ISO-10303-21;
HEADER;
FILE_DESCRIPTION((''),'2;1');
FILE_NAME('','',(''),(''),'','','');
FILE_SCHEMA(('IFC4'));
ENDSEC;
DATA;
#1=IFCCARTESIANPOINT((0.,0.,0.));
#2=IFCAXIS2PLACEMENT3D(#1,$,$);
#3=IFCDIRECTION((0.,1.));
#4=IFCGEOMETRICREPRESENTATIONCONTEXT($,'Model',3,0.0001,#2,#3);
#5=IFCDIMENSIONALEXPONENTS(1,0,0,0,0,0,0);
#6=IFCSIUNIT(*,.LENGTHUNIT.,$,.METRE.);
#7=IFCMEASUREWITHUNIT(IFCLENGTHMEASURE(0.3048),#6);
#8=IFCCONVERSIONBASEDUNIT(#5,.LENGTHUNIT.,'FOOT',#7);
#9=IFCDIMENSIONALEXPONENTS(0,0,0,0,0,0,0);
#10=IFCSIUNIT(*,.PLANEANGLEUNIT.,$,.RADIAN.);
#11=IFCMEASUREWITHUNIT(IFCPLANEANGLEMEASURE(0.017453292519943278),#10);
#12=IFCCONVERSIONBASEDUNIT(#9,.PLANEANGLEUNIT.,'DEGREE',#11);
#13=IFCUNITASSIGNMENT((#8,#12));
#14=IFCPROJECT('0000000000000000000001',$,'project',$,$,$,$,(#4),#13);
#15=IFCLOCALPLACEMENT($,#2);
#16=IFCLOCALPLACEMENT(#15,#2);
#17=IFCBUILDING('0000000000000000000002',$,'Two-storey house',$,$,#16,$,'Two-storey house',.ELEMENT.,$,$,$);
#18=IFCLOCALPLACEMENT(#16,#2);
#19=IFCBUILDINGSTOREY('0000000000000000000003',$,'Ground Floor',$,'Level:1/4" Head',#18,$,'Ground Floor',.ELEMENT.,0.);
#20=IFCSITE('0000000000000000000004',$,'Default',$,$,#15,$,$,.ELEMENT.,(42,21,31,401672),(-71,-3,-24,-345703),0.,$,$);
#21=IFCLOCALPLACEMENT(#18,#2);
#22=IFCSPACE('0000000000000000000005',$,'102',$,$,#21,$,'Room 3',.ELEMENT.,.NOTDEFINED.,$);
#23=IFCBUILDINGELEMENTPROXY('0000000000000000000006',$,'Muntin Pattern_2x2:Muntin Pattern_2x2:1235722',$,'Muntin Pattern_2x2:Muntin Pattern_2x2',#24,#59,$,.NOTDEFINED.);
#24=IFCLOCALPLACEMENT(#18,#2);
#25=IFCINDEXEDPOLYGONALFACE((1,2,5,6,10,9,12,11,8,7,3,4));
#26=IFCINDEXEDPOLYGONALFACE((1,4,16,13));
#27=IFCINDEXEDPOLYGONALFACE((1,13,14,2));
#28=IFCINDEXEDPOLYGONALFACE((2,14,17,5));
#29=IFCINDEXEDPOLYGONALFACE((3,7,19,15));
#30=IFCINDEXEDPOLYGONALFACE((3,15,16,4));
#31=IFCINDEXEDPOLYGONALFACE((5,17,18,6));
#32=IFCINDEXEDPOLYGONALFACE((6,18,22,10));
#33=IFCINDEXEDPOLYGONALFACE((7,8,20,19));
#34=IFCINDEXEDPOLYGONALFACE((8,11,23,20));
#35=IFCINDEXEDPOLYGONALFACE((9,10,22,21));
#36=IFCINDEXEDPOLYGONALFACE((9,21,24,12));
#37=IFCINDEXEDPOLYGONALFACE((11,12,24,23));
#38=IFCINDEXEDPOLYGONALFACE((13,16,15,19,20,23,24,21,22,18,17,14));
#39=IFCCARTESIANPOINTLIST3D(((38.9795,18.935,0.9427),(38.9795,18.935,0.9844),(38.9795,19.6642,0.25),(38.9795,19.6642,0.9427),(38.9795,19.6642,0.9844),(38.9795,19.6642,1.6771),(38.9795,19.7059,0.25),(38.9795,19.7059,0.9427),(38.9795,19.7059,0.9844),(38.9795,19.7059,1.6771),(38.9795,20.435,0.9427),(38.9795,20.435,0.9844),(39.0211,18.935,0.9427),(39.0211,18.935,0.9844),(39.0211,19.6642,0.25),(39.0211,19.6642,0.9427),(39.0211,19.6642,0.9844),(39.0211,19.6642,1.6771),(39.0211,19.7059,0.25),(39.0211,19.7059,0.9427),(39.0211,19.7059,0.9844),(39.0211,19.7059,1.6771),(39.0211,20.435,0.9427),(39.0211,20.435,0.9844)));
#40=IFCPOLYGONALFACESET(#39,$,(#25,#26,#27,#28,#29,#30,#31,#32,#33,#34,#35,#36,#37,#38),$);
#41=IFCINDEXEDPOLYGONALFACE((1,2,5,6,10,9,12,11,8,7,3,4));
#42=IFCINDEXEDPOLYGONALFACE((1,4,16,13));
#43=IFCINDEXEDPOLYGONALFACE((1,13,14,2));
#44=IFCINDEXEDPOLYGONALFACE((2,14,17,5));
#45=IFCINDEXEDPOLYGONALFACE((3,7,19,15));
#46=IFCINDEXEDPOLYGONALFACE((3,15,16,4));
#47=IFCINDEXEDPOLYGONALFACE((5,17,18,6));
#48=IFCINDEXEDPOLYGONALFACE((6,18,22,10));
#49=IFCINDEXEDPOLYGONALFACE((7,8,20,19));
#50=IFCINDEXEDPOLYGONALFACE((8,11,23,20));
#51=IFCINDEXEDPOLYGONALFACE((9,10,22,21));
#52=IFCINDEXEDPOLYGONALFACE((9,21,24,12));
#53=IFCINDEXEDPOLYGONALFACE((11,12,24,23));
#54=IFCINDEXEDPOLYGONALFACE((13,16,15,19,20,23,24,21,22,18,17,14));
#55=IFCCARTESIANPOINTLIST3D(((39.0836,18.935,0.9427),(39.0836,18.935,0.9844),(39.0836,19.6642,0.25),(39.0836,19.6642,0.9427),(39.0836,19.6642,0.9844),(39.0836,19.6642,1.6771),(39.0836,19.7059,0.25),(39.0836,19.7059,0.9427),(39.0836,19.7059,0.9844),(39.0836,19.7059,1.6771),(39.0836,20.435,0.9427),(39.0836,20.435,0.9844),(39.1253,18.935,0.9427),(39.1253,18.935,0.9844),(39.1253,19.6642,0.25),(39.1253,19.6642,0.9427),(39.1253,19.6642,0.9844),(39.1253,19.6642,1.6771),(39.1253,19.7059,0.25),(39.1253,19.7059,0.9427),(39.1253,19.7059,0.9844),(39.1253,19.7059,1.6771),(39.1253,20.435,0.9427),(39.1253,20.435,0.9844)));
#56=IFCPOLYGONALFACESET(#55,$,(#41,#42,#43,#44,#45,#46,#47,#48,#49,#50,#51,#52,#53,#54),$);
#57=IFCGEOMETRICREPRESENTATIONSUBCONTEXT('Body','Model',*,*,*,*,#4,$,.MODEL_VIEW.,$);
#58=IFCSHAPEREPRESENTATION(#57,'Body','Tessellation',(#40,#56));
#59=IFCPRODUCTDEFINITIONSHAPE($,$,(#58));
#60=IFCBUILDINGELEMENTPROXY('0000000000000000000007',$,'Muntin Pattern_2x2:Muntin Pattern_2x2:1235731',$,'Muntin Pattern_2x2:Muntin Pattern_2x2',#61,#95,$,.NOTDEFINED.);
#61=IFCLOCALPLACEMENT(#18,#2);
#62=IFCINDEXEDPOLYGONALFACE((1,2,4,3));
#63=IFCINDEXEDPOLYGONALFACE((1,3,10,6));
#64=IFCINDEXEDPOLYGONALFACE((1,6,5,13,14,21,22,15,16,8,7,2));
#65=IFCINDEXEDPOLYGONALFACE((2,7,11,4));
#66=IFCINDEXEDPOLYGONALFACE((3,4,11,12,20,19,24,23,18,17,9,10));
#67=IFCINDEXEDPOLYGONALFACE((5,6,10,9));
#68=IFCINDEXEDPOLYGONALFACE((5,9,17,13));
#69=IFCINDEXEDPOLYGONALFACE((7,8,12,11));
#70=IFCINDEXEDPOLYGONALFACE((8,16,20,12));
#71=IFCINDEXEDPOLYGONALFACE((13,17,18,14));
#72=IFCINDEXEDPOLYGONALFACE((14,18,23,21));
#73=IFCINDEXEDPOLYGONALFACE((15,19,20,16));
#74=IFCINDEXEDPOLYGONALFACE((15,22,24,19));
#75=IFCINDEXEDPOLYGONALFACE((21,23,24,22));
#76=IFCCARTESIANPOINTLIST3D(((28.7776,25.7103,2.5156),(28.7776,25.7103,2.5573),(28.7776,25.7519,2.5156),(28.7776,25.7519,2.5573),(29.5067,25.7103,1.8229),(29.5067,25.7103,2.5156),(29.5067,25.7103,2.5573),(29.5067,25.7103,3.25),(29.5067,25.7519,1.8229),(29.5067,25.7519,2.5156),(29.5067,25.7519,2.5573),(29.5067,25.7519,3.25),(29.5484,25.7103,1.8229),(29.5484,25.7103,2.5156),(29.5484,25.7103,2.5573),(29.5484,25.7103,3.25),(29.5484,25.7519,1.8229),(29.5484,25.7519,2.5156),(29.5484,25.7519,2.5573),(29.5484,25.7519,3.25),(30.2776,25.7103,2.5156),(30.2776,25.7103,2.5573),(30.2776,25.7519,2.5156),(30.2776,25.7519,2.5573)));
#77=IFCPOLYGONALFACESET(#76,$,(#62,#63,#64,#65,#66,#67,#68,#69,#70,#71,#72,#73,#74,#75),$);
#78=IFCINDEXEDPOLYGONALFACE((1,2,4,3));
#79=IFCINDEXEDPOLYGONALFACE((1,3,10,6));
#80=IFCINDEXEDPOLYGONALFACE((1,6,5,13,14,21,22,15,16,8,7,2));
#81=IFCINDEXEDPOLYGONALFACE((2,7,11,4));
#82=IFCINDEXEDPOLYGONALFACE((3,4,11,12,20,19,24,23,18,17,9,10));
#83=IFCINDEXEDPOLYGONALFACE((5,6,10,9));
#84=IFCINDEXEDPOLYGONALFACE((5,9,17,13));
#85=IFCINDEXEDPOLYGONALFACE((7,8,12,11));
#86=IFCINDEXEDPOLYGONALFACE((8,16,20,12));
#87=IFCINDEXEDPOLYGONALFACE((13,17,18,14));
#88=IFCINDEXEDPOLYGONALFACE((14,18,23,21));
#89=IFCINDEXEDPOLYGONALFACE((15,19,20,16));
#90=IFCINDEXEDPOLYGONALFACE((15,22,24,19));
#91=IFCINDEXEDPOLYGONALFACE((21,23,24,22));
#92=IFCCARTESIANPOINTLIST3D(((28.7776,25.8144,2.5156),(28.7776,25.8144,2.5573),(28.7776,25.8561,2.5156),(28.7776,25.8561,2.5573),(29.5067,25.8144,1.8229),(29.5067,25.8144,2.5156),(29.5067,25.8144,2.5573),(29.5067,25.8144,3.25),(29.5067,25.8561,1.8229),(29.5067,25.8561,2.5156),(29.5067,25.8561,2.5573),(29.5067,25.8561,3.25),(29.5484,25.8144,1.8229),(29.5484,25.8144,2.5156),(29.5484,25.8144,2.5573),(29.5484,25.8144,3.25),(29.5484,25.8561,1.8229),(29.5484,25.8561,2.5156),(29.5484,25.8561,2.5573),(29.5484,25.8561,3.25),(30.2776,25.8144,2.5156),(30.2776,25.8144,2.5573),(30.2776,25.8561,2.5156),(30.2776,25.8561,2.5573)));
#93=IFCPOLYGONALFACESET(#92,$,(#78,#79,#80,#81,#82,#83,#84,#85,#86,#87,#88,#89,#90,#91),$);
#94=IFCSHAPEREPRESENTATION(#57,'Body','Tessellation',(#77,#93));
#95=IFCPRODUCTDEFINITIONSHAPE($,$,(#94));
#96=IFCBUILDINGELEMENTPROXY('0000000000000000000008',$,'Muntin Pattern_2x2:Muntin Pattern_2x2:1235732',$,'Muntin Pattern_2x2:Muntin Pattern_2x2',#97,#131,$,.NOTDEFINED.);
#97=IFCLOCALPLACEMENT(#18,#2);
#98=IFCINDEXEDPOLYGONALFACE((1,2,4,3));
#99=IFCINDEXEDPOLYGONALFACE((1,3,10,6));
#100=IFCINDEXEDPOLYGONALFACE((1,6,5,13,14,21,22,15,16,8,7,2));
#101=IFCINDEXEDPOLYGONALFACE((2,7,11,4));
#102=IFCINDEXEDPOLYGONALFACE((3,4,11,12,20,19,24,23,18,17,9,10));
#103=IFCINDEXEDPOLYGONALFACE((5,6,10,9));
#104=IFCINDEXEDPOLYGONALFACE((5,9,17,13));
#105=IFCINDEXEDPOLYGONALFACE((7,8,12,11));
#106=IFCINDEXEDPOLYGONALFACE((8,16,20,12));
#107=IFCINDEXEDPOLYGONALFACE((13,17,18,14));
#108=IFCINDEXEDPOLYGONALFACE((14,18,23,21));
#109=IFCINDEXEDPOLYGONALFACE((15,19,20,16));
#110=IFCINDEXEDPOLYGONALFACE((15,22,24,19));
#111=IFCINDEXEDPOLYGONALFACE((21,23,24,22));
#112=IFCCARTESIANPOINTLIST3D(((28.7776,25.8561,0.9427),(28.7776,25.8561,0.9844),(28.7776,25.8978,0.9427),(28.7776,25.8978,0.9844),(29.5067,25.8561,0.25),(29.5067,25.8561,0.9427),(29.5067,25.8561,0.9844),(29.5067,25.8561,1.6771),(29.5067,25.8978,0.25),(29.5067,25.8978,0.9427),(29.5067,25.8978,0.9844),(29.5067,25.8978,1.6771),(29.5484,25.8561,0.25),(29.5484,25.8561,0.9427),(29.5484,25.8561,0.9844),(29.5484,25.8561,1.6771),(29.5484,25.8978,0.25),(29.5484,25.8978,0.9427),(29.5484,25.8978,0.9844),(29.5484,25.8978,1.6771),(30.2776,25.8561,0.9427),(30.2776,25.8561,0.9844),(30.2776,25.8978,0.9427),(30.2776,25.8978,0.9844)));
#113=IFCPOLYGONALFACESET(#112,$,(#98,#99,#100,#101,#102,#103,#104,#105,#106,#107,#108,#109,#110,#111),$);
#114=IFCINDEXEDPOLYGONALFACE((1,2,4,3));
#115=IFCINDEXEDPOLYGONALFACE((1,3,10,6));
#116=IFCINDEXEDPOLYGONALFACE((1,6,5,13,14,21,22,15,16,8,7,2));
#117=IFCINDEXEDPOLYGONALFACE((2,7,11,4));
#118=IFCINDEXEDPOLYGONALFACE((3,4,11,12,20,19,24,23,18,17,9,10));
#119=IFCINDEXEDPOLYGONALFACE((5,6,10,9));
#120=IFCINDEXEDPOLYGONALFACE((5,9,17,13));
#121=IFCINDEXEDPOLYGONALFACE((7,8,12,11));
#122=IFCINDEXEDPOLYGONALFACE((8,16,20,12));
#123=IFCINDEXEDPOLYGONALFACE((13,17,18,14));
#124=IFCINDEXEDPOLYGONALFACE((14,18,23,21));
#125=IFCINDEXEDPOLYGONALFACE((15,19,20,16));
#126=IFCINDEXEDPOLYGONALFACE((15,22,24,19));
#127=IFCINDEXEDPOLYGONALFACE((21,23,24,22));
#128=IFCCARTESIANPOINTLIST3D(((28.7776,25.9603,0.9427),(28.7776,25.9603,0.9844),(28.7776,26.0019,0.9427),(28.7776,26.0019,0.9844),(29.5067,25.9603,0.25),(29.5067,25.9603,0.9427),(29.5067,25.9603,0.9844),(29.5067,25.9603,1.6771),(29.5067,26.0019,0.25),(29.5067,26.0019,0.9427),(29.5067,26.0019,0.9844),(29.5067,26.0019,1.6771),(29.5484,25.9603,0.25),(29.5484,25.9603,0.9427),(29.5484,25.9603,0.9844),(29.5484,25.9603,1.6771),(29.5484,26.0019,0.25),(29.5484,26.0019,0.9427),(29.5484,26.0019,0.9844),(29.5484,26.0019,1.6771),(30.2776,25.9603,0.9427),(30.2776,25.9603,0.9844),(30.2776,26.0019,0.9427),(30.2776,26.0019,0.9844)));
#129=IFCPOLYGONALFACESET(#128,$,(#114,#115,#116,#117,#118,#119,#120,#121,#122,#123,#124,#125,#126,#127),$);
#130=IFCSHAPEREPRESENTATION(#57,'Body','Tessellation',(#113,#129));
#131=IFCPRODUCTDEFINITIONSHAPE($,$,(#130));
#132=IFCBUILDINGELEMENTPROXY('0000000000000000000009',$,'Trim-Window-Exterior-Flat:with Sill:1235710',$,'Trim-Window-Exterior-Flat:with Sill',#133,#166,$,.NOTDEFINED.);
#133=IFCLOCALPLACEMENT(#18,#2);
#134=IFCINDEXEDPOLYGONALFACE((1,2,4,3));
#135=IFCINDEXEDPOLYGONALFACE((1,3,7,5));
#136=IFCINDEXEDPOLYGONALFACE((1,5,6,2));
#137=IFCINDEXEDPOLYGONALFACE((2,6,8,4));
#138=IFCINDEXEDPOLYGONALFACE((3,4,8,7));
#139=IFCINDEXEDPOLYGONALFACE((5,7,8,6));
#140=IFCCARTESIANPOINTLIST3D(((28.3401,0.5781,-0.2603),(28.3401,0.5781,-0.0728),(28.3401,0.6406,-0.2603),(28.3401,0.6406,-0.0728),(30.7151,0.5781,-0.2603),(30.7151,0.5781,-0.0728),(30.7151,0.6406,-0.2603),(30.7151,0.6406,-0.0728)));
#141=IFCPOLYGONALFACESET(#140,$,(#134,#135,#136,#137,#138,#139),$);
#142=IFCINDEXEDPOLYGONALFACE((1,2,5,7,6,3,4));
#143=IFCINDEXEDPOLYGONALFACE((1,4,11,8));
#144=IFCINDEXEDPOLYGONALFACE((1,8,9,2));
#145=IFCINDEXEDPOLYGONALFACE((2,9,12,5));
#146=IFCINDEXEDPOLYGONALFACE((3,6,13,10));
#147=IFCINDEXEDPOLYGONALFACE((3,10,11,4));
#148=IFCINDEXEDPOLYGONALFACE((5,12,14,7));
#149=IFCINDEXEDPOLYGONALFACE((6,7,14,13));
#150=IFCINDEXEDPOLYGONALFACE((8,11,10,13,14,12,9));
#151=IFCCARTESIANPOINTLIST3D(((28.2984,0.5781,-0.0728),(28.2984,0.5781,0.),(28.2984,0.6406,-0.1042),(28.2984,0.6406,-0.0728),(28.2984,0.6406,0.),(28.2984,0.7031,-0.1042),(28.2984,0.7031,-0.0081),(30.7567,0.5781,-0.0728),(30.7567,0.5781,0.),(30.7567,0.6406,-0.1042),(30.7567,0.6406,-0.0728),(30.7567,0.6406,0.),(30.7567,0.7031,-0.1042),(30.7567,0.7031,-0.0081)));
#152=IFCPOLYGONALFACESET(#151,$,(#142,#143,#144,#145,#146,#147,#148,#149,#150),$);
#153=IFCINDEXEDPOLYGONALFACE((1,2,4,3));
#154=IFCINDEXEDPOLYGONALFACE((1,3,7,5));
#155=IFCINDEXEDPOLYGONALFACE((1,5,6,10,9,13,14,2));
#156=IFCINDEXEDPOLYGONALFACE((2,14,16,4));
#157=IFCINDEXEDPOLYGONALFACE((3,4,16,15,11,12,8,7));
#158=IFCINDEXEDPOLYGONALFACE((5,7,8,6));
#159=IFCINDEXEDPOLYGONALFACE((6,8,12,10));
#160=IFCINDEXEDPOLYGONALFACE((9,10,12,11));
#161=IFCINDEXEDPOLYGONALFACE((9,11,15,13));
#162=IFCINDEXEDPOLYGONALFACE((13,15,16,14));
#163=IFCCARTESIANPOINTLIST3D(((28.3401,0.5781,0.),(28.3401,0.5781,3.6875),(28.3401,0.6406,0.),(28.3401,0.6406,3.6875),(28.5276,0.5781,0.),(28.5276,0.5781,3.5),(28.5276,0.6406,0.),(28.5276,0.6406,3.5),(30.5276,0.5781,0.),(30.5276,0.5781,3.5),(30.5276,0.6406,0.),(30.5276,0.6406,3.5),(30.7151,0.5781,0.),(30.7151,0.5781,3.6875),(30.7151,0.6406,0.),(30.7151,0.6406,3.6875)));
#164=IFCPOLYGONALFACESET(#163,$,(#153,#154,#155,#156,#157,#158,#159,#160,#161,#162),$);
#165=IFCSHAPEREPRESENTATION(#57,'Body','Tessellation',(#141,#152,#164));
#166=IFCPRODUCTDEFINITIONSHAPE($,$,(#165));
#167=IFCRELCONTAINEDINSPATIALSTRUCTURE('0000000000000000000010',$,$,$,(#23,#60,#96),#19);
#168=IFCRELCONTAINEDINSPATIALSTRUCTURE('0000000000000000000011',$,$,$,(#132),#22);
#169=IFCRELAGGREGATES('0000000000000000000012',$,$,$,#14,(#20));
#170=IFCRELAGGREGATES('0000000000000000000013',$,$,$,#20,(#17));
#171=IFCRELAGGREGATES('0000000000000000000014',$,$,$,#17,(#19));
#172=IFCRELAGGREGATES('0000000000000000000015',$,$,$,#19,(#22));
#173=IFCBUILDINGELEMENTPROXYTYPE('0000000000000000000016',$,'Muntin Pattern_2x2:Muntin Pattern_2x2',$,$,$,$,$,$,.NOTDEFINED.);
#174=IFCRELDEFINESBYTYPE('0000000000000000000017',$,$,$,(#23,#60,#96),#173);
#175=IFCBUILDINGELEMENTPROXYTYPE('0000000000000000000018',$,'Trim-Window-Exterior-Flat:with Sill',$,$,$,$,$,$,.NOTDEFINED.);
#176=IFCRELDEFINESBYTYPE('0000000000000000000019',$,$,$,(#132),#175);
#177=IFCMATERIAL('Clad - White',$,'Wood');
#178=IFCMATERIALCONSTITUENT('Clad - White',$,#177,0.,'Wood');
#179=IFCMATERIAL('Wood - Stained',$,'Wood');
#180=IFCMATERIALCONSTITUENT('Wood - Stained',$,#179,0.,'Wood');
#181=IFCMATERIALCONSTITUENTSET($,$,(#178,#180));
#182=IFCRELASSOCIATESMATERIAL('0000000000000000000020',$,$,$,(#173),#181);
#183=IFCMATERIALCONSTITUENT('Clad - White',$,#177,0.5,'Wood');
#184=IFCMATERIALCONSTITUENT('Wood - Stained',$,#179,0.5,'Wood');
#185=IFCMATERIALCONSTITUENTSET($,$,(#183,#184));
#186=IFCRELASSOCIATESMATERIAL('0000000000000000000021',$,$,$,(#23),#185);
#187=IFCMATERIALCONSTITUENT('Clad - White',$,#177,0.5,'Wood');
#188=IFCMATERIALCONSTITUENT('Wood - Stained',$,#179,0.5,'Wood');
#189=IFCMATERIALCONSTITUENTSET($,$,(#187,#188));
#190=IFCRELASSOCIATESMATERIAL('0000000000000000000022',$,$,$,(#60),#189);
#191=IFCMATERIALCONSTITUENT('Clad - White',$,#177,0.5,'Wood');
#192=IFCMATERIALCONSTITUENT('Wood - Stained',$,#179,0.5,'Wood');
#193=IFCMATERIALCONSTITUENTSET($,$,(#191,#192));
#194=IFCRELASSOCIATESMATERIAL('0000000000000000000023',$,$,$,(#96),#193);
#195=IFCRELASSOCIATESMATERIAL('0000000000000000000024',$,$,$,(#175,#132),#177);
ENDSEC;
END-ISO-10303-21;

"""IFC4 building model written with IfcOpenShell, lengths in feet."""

from ifc_helpers import new_model, entity, si_unit, converted_unit, direction, frame, origin, place, context, subcontext, project, spatial, indexed_curve, outline, extrude, source, transform, mapped, material, constituent, constituent_set, type_object, type_shapes, element, save


model = new_model("IFC4")

# Units and contexts
model_context = context("Model", 3, precision=0.0001, world=origin(), true_north=direction((0.0, 1.0)))
body_context = subcontext(model_context, "Body", "Model", "MODEL_VIEW")
ifc_project = project(units=[converted_unit("LENGTHUNIT", "FOOT", entity("IfcLengthMeasure", 0.3048), si_unit("LENGTHUNIT", "METRE"), dimensions=[1, 0, 0, 0, 0, 0, 0]), converted_unit("PLANEANGLEUNIT", "DEGREE", entity("IfcPlaneAngleMeasure", 0.017453292519943278), si_unit("PLANEANGLEUNIT", "RADIAN"), dimensions=[0, 0, 0, 0, 0, 0, 0])], contexts=[model_context])

# Site, building, storey
site_placement = place(None, origin())
site = spatial("IfcSite", under=ifc_project, at=site_placement, Name="Default", CompositionType="ELEMENT", RefLatitude=(42, 21, 31, 401672), RefLongitude=(-71, -3, -24, -345703), RefElevation=0.0)
building_placement = place(site_placement, origin())
building = spatial("IfcBuilding", under=site, at=building_placement, Name="Two-storey house", LongName="Two-storey house", CompositionType="ELEMENT")
storey_placement = place(building_placement, origin())
storey = spatial("IfcBuildingStorey", under=building, at=storey_placement, Name="Ground Floor", ObjectType="Level:1/4\" Head", LongName="Ground Floor", CompositionType="ELEMENT", Elevation=0.0)

# Shared definitions
ifc_material_1 = material(Name="Wood - Stained", Category="Wood")

# Building element proxies
ifc_material_2 = material(Name="Clad - White", Category="Wood")
ifc_constituent_1 = constituent(ifc_material_2, Name="Clad - White", Category="Wood", fraction=0.0)
ifc_constituent_2 = constituent(ifc_material_1, Name="Wood - Stained", Category="Wood", fraction=0.0)
ifc_constituent_set_1 = constituent_set(constituents=[ifc_constituent_1, ifc_constituent_2])
building_element_proxy_type_1 = type_object("IfcBuildingElementProxyType", Name="Muntin Pattern_2x2:Muntin Pattern_2x2", PredefinedType="NOTDEFINED", material=ifc_constituent_set_1)
shared_shape_1 = source(origin(), body_context, "Body", "SweptSolid", [
    extrude(outline(indexed_curve([(0.0208, -0.0208), (0.7135, -0.0208), (0.7135, 0.0208), (0.0208, 0.0208), (0.0208, 0.75), (-0.0208, 0.75), (-0.0208, 0.0208), (-0.7135, 0.0208), (-0.7135, -0.0208), (-0.0208, -0.0208), (-0.0208, -0.75), (0.0208, -0.75), (0.0208, -0.0208)], self_intersect=False)), frame((0.0, 0.0312, 0.7135), z_axis=(0.0, 1.0, 0.0), x_axis=(0.0, 0.0, 1.0)), (0.0, 0.0, 1.0), 0.0417),
    extrude(outline(indexed_curve([(0.0208, -0.0208), (0.7135, -0.0208), (0.7135, 0.0208), (0.0208, 0.0208), (0.0208, 0.75), (-0.0208, 0.75), (-0.0208, 0.0208), (-0.7135, 0.0208), (-0.7135, -0.0208), (-0.0208, -0.0208), (-0.0208, -0.75), (0.0208, -0.75), (0.0208, -0.0208)], self_intersect=False)), frame((0.0, -0.0729, 0.7135), z_axis=(0.0, 1.0, 0.0), x_axis=(0.0, 0.0, 1.0)), (0.0, 0.0, 1.0), 0.0417),
])
type_shapes(building_element_proxy_type_1, [shared_shape_1])
ifc_constituent_3 = constituent(ifc_material_2, Name="Clad - White", Category="Wood", fraction=0.5)
ifc_constituent_4 = constituent(ifc_material_1, Name="Wood - Stained", Category="Wood", fraction=0.5)
ifc_constituent_set_2 = constituent_set(constituents=[ifc_constituent_3, ifc_constituent_4])
proxy_1_placement = place(storey_placement, frame((39.0524, 19.685, 0.25), z_axis=(0.0, 0.0, 1.0), x_axis=(0.0, 1.0, 0.0)))
element("IfcBuildingElementProxy", 1, at=proxy_1_placement, inside=storey, type_object=building_element_proxy_type_1, material=ifc_constituent_set_2, Name="Muntin Pattern_2x2:Muntin Pattern_2x2:1235722", ObjectType="Muntin Pattern_2x2:Muntin Pattern_2x2", PredefinedType="NOTDEFINED", context=body_context, shape_type="MappedRepresentation", body=[
    mapped(shared_shape_1, transform((0.0, 0.0, 0.0), scale=1.0)),
])
ifc_constituent_5 = constituent(ifc_material_2, Name="Clad - White", Category="Wood", fraction=0.5)
ifc_constituent_6 = constituent(ifc_material_1, Name="Wood - Stained", Category="Wood", fraction=0.5)
ifc_constituent_set_3 = constituent_set(constituents=[ifc_constituent_5, ifc_constituent_6])
proxy_2_placement = place(storey_placement, frame((29.5276, 25.7832, 1.8229), z_axis=(0.0, 0.0, 1.0), x_axis=(-1.0, 0.0, 0.0)))
element("IfcBuildingElementProxy", 2, at=proxy_2_placement, inside=storey, type_object=building_element_proxy_type_1, material=ifc_constituent_set_3, Name="Muntin Pattern_2x2:Muntin Pattern_2x2:1235731", ObjectType="Muntin Pattern_2x2:Muntin Pattern_2x2", PredefinedType="NOTDEFINED", context=body_context, shape_type="MappedRepresentation", body=[
    mapped(shared_shape_1, transform((0.0, 0.0, 0.0), scale=1.0)),
])
ifc_constituent_7 = constituent(ifc_material_2, Name="Clad - White", Category="Wood", fraction=0.5)
ifc_constituent_8 = constituent(ifc_material_1, Name="Wood - Stained", Category="Wood", fraction=0.5)
ifc_constituent_set_4 = constituent_set(constituents=[ifc_constituent_7, ifc_constituent_8])
proxy_3_placement = place(storey_placement, frame((29.5276, 25.929, 0.25), z_axis=(0.0, 0.0, 1.0), x_axis=(-1.0, 0.0, 0.0)))
element("IfcBuildingElementProxy", 3, at=proxy_3_placement, inside=storey, type_object=building_element_proxy_type_1, material=ifc_constituent_set_4, Name="Muntin Pattern_2x2:Muntin Pattern_2x2:1235732", ObjectType="Muntin Pattern_2x2:Muntin Pattern_2x2", PredefinedType="NOTDEFINED", context=body_context, shape_type="MappedRepresentation", body=[
    mapped(shared_shape_1, transform((0.0, 0.0, 0.0), scale=1.0)),
])

# Shared definitions
space_1_placement = place(storey_placement, origin())
space_1 = spatial("IfcSpace", under=storey, at=space_1_placement, Name="102", LongName="Room 3", CompositionType="ELEMENT", PredefinedType="NOTDEFINED")

# Building element proxy
building_element_proxy_type_2 = type_object("IfcBuildingElementProxyType", Name="Trim-Window-Exterior-Flat:with Sill", PredefinedType="NOTDEFINED", material=ifc_material_2)
shared_shape_2 = source(origin(), body_context, "Body", "SweptSolid", [
    extrude(outline(indexed_curve([(-1.1875, -0.0938), (1.1875, -0.0938), (1.1875, 0.0938), (-1.1875, 0.0938), (-1.1875, -0.0938)], self_intersect=False)), frame((0.0, -3.6665, 0.0), z_axis=(0.0, 0.0, 1.0), x_axis=(-1.0, 0.0, 0.0)), (0.0, 0.0, 1.0), 0.0625),
    extrude(outline(indexed_curve([(-0.0625, -0.0525), (0.0, -0.0525), (0.0, -0.0211), (0.0625, -0.0211), (0.0625, 0.0517), (0.0, 0.0517), (-0.0625, 0.0436), (-0.0625, -0.0525)], self_intersect=False)), frame((-1.2292, -3.5517, 0.0625), z_axis=(1.0, 0.0, 0.0), x_axis=(0.0, 0.0, -1.0)), (0.0, 0.0, 1.0), 2.4583),
    extrude(outline(indexed_curve([(-1.8906, -1.1875), (1.7969, -1.1875), (1.7969, -1.0), (-1.7031, -1.0), (-1.7031, 1.0), (1.7969, 1.0), (1.7969, 1.1875), (-1.8906, 1.1875), (-1.8906, -1.1875)], self_intersect=False)), frame((0.0, -1.7031, 0.0), z_axis=(0.0, 0.0, 1.0), x_axis=(0.0, -1.0, 0.0)), (0.0, 0.0, 1.0), 0.0625),
])
type_shapes(building_element_proxy_type_2, [shared_shape_2])
for number, where, z_axis, x_axis, name in (
    (4, (29.5276, 0.5781, 3.5), (0.0, 1.0, 0.0), (-1.0, 0.0, 0.0), "Trim-Window-Exterior-Flat:with Sill:1235710"),
):
    element("IfcBuildingElementProxy", number, at=place(space_1_placement, frame(where, z_axis=z_axis, x_axis=x_axis)), inside=space_1, type_object=building_element_proxy_type_2, material=ifc_material_2, Name=name, ObjectType="Trim-Window-Exterior-Flat:with Sill", PredefinedType="NOTDEFINED", context=body_context, shape_type="MappedRepresentation", body=[
        mapped(shared_shape_2, transform((0.0, 0.0, 0.0), scale=1.0)),
    ])

save(model, "model.ifc")
